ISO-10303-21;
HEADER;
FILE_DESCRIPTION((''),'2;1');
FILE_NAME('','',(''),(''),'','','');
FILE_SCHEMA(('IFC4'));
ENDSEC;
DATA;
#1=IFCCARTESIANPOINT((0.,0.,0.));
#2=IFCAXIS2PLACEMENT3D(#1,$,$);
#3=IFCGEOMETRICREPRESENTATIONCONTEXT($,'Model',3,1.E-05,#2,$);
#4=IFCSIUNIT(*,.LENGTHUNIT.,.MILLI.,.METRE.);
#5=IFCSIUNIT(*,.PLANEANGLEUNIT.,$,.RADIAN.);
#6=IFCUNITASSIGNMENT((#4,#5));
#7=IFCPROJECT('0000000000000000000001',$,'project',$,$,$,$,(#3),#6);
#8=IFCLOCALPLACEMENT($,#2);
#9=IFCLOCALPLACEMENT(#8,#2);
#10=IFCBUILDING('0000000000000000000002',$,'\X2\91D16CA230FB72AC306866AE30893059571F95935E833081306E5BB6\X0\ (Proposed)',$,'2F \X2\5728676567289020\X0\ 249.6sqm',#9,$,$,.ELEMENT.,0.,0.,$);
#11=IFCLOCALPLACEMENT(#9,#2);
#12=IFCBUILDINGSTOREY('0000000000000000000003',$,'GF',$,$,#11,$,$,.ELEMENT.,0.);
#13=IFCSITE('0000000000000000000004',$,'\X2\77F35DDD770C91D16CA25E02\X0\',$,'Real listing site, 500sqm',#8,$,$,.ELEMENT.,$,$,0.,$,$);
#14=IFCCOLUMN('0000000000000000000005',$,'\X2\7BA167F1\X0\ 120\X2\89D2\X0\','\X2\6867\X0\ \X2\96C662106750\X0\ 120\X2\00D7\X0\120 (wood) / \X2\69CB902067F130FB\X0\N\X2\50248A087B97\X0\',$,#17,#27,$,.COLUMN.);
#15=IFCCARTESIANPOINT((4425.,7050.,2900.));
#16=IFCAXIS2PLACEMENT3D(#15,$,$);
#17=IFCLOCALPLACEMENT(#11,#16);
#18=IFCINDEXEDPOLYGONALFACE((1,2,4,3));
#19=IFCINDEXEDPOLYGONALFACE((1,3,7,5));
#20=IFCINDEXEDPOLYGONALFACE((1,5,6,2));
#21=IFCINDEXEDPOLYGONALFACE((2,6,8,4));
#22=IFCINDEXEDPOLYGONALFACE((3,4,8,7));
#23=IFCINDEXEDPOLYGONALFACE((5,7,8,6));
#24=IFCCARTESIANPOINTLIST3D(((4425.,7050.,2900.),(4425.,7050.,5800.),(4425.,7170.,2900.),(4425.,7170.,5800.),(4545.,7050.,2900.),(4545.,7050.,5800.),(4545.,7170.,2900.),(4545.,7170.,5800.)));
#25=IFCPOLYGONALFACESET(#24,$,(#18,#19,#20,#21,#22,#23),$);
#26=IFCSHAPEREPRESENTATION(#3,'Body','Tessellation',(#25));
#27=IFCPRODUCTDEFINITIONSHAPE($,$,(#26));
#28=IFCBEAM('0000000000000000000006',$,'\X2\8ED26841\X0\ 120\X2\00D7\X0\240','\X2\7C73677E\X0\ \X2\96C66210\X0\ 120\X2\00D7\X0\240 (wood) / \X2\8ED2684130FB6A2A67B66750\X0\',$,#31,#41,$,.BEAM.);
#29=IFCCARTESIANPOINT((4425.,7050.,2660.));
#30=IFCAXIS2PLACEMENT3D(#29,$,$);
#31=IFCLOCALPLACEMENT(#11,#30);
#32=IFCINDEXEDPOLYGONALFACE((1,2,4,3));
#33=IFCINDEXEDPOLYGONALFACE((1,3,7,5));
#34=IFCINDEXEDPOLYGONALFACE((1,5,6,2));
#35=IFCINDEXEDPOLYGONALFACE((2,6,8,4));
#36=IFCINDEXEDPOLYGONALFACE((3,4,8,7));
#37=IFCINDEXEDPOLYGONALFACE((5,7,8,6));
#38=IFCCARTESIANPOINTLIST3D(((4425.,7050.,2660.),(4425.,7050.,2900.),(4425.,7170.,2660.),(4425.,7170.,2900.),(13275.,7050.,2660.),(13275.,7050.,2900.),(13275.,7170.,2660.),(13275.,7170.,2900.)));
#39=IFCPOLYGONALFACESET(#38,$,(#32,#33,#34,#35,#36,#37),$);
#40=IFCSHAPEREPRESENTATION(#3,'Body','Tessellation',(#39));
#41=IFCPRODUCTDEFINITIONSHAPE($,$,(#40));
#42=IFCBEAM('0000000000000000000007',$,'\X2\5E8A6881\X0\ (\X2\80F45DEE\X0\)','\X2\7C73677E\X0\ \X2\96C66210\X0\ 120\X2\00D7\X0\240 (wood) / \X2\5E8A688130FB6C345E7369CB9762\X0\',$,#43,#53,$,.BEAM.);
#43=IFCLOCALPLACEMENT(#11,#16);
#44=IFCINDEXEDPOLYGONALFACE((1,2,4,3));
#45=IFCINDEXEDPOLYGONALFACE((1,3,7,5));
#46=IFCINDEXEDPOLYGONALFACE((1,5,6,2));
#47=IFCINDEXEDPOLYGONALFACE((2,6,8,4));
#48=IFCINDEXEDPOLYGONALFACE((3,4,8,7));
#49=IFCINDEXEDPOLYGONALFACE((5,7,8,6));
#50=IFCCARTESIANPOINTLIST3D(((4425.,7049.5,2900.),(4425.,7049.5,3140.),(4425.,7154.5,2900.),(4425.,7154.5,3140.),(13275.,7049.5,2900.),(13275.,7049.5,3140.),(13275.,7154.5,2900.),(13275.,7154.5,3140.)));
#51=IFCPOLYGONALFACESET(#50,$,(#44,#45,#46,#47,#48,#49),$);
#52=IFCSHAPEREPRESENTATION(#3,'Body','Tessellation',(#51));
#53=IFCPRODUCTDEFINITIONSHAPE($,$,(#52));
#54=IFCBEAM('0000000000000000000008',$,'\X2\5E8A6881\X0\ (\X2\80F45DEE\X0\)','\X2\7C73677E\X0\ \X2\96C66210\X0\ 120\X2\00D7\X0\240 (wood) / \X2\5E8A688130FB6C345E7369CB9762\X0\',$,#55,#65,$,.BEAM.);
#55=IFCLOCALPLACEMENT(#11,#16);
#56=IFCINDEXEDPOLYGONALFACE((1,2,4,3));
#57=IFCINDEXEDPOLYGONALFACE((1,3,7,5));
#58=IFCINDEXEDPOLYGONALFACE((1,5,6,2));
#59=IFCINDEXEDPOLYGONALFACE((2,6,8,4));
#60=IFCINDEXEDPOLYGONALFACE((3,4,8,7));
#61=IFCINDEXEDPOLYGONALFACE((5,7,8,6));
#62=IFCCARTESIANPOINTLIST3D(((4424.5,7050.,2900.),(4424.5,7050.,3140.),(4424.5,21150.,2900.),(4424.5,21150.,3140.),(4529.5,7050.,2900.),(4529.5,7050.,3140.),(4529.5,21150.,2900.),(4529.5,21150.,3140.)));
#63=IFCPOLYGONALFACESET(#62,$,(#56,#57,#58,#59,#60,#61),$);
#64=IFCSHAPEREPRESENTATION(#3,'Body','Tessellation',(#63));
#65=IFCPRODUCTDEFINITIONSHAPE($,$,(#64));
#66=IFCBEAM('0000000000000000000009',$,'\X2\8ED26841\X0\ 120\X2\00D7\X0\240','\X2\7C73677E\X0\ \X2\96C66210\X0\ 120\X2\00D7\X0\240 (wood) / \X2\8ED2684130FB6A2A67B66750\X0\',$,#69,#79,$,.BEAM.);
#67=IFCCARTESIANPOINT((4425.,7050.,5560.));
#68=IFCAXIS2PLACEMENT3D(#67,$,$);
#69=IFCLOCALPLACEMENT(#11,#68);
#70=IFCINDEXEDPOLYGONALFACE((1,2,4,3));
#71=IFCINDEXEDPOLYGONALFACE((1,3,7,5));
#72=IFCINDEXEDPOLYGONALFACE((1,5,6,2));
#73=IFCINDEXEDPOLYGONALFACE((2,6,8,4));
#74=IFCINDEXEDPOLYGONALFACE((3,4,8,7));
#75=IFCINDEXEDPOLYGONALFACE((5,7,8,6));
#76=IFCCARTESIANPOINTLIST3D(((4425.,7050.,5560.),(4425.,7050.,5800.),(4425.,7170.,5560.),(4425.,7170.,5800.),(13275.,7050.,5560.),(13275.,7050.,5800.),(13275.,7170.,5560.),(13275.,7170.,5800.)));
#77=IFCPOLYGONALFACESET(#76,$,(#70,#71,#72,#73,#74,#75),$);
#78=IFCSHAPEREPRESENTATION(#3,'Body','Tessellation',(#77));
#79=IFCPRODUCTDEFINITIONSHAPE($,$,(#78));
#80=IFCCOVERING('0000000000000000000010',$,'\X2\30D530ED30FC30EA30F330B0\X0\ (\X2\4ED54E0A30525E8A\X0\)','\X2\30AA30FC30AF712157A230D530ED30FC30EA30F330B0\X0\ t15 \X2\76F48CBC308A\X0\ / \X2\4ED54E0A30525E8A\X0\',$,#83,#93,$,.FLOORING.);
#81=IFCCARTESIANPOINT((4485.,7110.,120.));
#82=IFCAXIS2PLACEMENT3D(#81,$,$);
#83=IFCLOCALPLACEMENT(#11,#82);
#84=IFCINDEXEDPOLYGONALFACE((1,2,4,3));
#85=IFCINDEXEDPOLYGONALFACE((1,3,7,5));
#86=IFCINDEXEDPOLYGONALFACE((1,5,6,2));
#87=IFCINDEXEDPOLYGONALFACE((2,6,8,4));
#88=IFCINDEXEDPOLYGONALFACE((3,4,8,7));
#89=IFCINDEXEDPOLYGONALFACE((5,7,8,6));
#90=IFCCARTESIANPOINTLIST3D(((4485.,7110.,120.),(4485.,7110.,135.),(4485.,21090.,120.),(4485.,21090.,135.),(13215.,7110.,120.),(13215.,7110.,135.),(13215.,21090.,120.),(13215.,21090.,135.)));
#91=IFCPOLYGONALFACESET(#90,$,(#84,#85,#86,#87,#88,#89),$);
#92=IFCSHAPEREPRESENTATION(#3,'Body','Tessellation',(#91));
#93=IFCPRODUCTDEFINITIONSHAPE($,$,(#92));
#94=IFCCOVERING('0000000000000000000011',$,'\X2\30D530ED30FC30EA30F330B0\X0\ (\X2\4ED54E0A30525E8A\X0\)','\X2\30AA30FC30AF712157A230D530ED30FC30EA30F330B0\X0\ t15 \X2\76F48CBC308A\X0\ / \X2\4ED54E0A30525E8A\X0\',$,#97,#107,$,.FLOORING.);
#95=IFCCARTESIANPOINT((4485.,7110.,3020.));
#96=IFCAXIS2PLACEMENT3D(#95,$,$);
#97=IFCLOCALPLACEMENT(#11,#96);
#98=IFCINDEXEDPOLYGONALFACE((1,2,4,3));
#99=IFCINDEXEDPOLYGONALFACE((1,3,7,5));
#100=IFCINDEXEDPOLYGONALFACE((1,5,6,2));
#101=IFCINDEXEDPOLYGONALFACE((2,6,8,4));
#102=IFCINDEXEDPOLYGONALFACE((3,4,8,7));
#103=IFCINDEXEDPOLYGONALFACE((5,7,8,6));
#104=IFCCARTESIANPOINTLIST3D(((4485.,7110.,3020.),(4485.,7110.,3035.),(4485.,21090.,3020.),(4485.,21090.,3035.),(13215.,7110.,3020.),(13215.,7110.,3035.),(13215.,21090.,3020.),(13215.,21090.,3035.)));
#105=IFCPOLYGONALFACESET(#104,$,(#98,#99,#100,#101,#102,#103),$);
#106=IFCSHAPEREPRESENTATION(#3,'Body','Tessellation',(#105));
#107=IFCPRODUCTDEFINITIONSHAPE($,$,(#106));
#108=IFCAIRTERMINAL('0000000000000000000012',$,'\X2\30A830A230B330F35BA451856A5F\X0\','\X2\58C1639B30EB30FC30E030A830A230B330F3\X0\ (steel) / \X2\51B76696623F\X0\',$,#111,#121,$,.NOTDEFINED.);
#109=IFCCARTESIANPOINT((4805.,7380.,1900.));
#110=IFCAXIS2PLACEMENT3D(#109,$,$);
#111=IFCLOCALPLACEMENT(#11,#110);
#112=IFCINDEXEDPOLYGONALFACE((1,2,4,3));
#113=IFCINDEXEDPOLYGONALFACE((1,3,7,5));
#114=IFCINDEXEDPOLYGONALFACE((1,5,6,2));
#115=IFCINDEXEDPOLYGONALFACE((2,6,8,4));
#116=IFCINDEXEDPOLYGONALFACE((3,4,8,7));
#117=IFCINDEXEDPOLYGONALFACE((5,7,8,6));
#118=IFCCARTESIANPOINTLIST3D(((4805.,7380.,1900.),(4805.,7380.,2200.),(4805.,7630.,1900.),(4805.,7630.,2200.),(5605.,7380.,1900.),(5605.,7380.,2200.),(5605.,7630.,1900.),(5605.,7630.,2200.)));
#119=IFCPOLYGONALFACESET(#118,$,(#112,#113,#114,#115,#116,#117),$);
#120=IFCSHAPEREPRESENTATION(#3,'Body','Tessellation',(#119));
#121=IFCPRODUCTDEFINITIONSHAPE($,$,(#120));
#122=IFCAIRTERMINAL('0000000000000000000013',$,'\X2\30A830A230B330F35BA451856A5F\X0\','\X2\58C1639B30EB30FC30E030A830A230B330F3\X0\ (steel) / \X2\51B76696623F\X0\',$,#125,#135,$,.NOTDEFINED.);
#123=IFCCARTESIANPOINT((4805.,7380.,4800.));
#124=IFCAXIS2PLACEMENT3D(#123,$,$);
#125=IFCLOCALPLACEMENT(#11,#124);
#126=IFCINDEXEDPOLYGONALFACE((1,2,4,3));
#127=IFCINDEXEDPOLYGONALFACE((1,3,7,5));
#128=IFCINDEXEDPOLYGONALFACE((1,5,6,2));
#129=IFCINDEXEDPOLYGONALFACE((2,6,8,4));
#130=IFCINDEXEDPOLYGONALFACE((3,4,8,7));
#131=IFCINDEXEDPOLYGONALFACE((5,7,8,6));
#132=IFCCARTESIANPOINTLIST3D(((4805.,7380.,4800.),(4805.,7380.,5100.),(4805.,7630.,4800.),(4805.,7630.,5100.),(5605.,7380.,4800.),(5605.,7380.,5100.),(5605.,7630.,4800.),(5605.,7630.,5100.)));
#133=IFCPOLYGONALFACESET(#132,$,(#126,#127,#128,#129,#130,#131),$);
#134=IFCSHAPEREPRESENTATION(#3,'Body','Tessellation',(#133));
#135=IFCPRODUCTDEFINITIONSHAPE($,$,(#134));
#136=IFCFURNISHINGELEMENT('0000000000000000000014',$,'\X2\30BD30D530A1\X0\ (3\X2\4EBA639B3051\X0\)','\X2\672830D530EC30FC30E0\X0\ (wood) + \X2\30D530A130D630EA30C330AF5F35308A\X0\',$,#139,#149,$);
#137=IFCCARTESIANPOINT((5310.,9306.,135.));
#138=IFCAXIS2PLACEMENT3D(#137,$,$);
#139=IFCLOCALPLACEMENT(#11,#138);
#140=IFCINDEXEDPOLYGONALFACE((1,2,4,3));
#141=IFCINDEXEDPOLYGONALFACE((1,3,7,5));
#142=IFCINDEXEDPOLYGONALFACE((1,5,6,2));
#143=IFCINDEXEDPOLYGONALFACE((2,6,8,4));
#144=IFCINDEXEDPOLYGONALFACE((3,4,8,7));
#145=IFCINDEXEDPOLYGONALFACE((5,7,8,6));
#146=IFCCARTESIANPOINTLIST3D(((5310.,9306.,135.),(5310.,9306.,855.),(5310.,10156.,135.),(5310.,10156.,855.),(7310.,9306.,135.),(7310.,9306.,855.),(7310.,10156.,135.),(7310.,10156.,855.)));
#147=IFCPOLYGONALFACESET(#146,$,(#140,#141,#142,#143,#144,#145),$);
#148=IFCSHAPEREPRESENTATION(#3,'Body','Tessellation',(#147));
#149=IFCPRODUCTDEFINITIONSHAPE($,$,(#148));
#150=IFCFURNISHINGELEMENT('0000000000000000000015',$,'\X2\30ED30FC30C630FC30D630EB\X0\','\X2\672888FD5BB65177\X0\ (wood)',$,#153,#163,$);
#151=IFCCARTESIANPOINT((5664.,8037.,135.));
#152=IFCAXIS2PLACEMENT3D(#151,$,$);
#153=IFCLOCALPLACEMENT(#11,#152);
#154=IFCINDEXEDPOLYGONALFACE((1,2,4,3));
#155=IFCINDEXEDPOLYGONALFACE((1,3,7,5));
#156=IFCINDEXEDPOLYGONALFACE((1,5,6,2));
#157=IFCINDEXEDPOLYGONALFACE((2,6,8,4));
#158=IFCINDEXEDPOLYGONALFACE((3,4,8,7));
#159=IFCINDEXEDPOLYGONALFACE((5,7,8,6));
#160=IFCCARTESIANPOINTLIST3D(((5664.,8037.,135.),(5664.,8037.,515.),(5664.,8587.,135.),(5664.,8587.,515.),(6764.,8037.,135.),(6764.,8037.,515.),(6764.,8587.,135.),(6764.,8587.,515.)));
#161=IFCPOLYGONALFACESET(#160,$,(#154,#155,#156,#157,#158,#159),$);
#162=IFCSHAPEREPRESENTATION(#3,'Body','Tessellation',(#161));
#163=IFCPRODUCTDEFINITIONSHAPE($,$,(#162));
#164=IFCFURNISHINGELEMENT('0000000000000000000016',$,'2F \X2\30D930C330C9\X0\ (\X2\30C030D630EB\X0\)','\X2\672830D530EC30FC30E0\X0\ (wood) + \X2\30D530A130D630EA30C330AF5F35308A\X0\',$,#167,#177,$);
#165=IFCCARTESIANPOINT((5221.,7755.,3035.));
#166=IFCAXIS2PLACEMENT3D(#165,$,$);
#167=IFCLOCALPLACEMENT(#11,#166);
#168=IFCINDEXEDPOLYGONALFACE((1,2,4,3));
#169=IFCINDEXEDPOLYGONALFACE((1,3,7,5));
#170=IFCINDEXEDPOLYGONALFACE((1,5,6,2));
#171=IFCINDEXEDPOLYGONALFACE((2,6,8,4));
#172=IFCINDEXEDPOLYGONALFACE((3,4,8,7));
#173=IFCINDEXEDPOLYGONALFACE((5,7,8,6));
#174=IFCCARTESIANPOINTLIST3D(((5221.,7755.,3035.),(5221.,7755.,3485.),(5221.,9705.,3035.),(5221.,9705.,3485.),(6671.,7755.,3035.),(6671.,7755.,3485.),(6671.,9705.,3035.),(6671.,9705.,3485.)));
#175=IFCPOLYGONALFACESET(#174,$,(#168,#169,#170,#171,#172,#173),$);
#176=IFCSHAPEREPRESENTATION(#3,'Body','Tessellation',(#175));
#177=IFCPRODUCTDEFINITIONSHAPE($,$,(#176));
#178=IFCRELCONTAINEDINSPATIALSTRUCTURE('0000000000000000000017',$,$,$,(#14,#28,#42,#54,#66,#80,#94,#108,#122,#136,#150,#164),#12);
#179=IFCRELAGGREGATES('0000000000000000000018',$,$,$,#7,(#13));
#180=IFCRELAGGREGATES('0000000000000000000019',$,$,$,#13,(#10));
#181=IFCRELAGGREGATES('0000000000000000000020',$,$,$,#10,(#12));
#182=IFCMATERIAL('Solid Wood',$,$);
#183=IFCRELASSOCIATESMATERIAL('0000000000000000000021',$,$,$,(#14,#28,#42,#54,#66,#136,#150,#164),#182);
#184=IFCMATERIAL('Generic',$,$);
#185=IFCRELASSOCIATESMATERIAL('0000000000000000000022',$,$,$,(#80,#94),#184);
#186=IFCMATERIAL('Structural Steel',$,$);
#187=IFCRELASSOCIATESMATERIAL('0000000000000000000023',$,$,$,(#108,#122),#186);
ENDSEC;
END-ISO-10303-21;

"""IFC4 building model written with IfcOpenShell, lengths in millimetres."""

from ifc_helpers import new_model, si_unit, frame, frame_2d, origin, place, context, project, spatial, rectangle, extrude, material, element, save


model = new_model("IFC4")

# Units and contexts
model_context = context("Model", 3, precision=1e-05, world=origin())
ifc_project = project(units=[si_unit("LENGTHUNIT", "METRE", prefix="MILLI"), si_unit("PLANEANGLEUNIT", "RADIAN")], contexts=[model_context])

# Site, building, storey
site_placement = place(None, origin())
site = spatial("IfcSite", under=ifc_project, at=site_placement, Name="石川県金沢市", ObjectType="Real listing site, 500sqm", CompositionType="ELEMENT", RefElevation=0.0)
building_placement = place(site_placement, origin())
building = spatial("IfcBuilding", under=site, at=building_placement, Name="金沢・犬と暮らす土間広めの家 (Proposed)", ObjectType="2F 在来木造 249.6sqm", CompositionType="ELEMENT", ElevationOfRefHeight=0.0, ElevationOfTerrain=0.0)
storey_placement = place(building_placement, origin())
storey = spatial("IfcBuildingStorey", under=building, at=storey_placement, Name="GF", CompositionType="ELEMENT", Elevation=0.0)

# Column
ifc_material_1 = material(Name="Solid Wood")
column_1_placement = place(storey_placement, frame((4425.0, 7050.0, 2900.0)))
element("IfcColumn", 1, at=column_1_placement, inside=storey, material=ifc_material_1, Name="管柱 120角", Description="桧 集成材 120×120 (wood) / 構造柱・N値計算", PredefinedType="COLUMN", context=model_context, shape_type="SweptSolid", body=[
    extrude(rectangle(XDim=120.0, YDim=120.0, at=frame_2d((60.0, 60.0))), frame((4425.0, 7050.0, 2900.0)), (0.0, 0.0, 1.0), 2900.0),
])

# Beams
beam_1_placement = place(storey_placement, frame((4425.0, 7050.0, 2660.0)))
element("IfcBeam", 2, at=beam_1_placement, inside=storey, material=ifc_material_1, Name="軒桁 120×240", Description="米松 集成 120×240 (wood) / 軒桁・横架材", PredefinedType="BEAM", context=model_context, shape_type="SweptSolid", body=[
    extrude(rectangle(XDim=8850.0, YDim=120.0, at=frame_2d((4425.0, 60.0))), frame((4425.0, 7050.0, 2660.0)), (0.0, 0.0, 1.0), 240.0),
])
beam_2_placement = place(storey_placement, frame((4425.0, 7050.0, 2900.0)))
element("IfcBeam", 3, at=beam_2_placement, inside=storey, material=ifc_material_1, Name="床梁 (胴差)", Description="米松 集成 120×240 (wood) / 床梁・水平構面", PredefinedType="BEAM", context=model_context, shape_type="SweptSolid", body=[
    extrude(rectangle(XDim=8850.0, YDim=105.0, at=frame_2d((4425.0, 52.0))), frame((4425.0, 7050.0, 2900.0)), (0.0, 0.0, 1.0), 240.0),
])
beam_3_placement = place(storey_placement, frame((4425.0, 7050.0, 2900.0)))
element("IfcBeam", 4, at=beam_3_placement, inside=storey, material=ifc_material_1, Name="床梁 (胴差)", Description="米松 集成 120×240 (wood) / 床梁・水平構面", PredefinedType="BEAM", context=model_context, shape_type="SweptSolid", body=[
    extrude(rectangle(XDim=105.0, YDim=14100.0, at=frame_2d((52.0, 7050.0))), frame((4425.0, 7050.0, 2900.0)), (0.0, 0.0, 1.0), 240.0),
])
beam_4_placement = place(storey_placement, frame((4425.0, 7050.0, 5560.0)))
element("IfcBeam", 5, at=beam_4_placement, inside=storey, material=ifc_material_1, Name="軒桁 120×240", Description="米松 集成 120×240 (wood) / 軒桁・横架材", PredefinedType="BEAM", context=model_context, shape_type="SweptSolid", body=[
    extrude(rectangle(XDim=8850.0, YDim=120.0, at=frame_2d((4425.0, 60.0))), frame((4425.0, 7050.0, 5560.0)), (0.0, 0.0, 1.0), 240.0),
])

# Coverings
ifc_material_2 = material(Name="Generic")
covering_1_placement = place(storey_placement, frame((4485.0, 7110.0, 120.0)))
element("IfcCovering", 6, at=covering_1_placement, inside=storey, material=ifc_material_2, Name="フローリング (仕上げ床)", Description="オーク無垢フローリング t15 直貼り / 仕上げ床", PredefinedType="FLOORING", context=model_context, shape_type="SweptSolid", body=[
    extrude(rectangle(XDim=8730.0, YDim=13980.0, at=frame_2d((4365.0, 6990.0))), frame((4485.0, 7110.0, 120.0)), (0.0, 0.0, 1.0), 15.0),
])
covering_2_placement = place(storey_placement, frame((4485.0, 7110.0, 3020.0)))
element("IfcCovering", 7, at=covering_2_placement, inside=storey, material=ifc_material_2, Name="フローリング (仕上げ床)", Description="オーク無垢フローリング t15 直貼り / 仕上げ床", PredefinedType="FLOORING", context=model_context, shape_type="SweptSolid", body=[
    extrude(rectangle(XDim=8730.0, YDim=13980.0, at=frame_2d((4365.0, 6990.0))), frame((4485.0, 7110.0, 3020.0)), (0.0, 0.0, 1.0), 15.0),
])

# Air terminals
ifc_material_3 = material(Name="Structural Steel")
air_terminal_1_placement = place(storey_placement, frame((4805.0, 7380.0, 1900.0)))
element("IfcAirTerminal", 8, at=air_terminal_1_placement, inside=storey, material=ifc_material_3, Name="エアコン室内機", Description="壁掛ルームエアコン (steel) / 冷暖房", PredefinedType="NOTDEFINED", context=model_context, shape_type="SweptSolid", body=[
    extrude(rectangle(XDim=800.0, YDim=250.0, at=frame_2d((400.0, 125.0))), frame((4805.0, 7380.0, 1900.0)), (0.0, 0.0, 1.0), 300.0),
])
air_terminal_2_placement = place(storey_placement, frame((4805.0, 7380.0, 4800.0)))
element("IfcAirTerminal", 9, at=air_terminal_2_placement, inside=storey, material=ifc_material_3, Name="エアコン室内機", Description="壁掛ルームエアコン (steel) / 冷暖房", PredefinedType="NOTDEFINED", context=model_context, shape_type="SweptSolid", body=[
    extrude(rectangle(XDim=800.0, YDim=250.0, at=frame_2d((400.0, 125.0))), frame((4805.0, 7380.0, 4800.0)), (0.0, 0.0, 1.0), 300.0),
])

# Furnishing elements
furnishing_1_placement = place(storey_placement, frame((5310.0, 9306.0, 135.0)))
element("IfcFurnishingElement", 10, at=furnishing_1_placement, inside=storey, material=ifc_material_1, Name="ソファ (3人掛け)", Description="木フレーム (wood) + ファブリック張り", context=model_context, shape_type="SweptSolid", body=[
    extrude(rectangle(XDim=2000.0, YDim=850.0, at=frame_2d((1000.0, 425.0))), frame((5310.0, 9306.0, 135.0)), (0.0, 0.0, 1.0), 720.0),
])
furnishing_2_placement = place(storey_placement, frame((5664.0, 8037.0, 135.0)))
element("IfcFurnishingElement", 11, at=furnishing_2_placement, inside=storey, material=ifc_material_1, Name="ローテーブル", Description="木製家具 (wood)", context=model_context, shape_type="SweptSolid", body=[
    extrude(rectangle(XDim=1100.0, YDim=550.0, at=frame_2d((550.0, 275.0))), frame((5664.0, 8037.0, 135.0)), (0.0, 0.0, 1.0), 380.0),
])
furnishing_3_placement = place(storey_placement, frame((5221.0, 7755.0, 3035.0)))
element("IfcFurnishingElement", 12, at=furnishing_3_placement, inside=storey, material=ifc_material_1, Name="2F ベッド (ダブル)", Description="木フレーム (wood) + ファブリック張り", context=model_context, shape_type="SweptSolid", body=[
    extrude(rectangle(XDim=1450.0, YDim=1950.0, at=frame_2d((725.0, 975.0))), frame((5221.0, 7755.0, 3035.0)), (0.0, 0.0, 1.0), 450.0),
])

save(model, "model.ifc")
